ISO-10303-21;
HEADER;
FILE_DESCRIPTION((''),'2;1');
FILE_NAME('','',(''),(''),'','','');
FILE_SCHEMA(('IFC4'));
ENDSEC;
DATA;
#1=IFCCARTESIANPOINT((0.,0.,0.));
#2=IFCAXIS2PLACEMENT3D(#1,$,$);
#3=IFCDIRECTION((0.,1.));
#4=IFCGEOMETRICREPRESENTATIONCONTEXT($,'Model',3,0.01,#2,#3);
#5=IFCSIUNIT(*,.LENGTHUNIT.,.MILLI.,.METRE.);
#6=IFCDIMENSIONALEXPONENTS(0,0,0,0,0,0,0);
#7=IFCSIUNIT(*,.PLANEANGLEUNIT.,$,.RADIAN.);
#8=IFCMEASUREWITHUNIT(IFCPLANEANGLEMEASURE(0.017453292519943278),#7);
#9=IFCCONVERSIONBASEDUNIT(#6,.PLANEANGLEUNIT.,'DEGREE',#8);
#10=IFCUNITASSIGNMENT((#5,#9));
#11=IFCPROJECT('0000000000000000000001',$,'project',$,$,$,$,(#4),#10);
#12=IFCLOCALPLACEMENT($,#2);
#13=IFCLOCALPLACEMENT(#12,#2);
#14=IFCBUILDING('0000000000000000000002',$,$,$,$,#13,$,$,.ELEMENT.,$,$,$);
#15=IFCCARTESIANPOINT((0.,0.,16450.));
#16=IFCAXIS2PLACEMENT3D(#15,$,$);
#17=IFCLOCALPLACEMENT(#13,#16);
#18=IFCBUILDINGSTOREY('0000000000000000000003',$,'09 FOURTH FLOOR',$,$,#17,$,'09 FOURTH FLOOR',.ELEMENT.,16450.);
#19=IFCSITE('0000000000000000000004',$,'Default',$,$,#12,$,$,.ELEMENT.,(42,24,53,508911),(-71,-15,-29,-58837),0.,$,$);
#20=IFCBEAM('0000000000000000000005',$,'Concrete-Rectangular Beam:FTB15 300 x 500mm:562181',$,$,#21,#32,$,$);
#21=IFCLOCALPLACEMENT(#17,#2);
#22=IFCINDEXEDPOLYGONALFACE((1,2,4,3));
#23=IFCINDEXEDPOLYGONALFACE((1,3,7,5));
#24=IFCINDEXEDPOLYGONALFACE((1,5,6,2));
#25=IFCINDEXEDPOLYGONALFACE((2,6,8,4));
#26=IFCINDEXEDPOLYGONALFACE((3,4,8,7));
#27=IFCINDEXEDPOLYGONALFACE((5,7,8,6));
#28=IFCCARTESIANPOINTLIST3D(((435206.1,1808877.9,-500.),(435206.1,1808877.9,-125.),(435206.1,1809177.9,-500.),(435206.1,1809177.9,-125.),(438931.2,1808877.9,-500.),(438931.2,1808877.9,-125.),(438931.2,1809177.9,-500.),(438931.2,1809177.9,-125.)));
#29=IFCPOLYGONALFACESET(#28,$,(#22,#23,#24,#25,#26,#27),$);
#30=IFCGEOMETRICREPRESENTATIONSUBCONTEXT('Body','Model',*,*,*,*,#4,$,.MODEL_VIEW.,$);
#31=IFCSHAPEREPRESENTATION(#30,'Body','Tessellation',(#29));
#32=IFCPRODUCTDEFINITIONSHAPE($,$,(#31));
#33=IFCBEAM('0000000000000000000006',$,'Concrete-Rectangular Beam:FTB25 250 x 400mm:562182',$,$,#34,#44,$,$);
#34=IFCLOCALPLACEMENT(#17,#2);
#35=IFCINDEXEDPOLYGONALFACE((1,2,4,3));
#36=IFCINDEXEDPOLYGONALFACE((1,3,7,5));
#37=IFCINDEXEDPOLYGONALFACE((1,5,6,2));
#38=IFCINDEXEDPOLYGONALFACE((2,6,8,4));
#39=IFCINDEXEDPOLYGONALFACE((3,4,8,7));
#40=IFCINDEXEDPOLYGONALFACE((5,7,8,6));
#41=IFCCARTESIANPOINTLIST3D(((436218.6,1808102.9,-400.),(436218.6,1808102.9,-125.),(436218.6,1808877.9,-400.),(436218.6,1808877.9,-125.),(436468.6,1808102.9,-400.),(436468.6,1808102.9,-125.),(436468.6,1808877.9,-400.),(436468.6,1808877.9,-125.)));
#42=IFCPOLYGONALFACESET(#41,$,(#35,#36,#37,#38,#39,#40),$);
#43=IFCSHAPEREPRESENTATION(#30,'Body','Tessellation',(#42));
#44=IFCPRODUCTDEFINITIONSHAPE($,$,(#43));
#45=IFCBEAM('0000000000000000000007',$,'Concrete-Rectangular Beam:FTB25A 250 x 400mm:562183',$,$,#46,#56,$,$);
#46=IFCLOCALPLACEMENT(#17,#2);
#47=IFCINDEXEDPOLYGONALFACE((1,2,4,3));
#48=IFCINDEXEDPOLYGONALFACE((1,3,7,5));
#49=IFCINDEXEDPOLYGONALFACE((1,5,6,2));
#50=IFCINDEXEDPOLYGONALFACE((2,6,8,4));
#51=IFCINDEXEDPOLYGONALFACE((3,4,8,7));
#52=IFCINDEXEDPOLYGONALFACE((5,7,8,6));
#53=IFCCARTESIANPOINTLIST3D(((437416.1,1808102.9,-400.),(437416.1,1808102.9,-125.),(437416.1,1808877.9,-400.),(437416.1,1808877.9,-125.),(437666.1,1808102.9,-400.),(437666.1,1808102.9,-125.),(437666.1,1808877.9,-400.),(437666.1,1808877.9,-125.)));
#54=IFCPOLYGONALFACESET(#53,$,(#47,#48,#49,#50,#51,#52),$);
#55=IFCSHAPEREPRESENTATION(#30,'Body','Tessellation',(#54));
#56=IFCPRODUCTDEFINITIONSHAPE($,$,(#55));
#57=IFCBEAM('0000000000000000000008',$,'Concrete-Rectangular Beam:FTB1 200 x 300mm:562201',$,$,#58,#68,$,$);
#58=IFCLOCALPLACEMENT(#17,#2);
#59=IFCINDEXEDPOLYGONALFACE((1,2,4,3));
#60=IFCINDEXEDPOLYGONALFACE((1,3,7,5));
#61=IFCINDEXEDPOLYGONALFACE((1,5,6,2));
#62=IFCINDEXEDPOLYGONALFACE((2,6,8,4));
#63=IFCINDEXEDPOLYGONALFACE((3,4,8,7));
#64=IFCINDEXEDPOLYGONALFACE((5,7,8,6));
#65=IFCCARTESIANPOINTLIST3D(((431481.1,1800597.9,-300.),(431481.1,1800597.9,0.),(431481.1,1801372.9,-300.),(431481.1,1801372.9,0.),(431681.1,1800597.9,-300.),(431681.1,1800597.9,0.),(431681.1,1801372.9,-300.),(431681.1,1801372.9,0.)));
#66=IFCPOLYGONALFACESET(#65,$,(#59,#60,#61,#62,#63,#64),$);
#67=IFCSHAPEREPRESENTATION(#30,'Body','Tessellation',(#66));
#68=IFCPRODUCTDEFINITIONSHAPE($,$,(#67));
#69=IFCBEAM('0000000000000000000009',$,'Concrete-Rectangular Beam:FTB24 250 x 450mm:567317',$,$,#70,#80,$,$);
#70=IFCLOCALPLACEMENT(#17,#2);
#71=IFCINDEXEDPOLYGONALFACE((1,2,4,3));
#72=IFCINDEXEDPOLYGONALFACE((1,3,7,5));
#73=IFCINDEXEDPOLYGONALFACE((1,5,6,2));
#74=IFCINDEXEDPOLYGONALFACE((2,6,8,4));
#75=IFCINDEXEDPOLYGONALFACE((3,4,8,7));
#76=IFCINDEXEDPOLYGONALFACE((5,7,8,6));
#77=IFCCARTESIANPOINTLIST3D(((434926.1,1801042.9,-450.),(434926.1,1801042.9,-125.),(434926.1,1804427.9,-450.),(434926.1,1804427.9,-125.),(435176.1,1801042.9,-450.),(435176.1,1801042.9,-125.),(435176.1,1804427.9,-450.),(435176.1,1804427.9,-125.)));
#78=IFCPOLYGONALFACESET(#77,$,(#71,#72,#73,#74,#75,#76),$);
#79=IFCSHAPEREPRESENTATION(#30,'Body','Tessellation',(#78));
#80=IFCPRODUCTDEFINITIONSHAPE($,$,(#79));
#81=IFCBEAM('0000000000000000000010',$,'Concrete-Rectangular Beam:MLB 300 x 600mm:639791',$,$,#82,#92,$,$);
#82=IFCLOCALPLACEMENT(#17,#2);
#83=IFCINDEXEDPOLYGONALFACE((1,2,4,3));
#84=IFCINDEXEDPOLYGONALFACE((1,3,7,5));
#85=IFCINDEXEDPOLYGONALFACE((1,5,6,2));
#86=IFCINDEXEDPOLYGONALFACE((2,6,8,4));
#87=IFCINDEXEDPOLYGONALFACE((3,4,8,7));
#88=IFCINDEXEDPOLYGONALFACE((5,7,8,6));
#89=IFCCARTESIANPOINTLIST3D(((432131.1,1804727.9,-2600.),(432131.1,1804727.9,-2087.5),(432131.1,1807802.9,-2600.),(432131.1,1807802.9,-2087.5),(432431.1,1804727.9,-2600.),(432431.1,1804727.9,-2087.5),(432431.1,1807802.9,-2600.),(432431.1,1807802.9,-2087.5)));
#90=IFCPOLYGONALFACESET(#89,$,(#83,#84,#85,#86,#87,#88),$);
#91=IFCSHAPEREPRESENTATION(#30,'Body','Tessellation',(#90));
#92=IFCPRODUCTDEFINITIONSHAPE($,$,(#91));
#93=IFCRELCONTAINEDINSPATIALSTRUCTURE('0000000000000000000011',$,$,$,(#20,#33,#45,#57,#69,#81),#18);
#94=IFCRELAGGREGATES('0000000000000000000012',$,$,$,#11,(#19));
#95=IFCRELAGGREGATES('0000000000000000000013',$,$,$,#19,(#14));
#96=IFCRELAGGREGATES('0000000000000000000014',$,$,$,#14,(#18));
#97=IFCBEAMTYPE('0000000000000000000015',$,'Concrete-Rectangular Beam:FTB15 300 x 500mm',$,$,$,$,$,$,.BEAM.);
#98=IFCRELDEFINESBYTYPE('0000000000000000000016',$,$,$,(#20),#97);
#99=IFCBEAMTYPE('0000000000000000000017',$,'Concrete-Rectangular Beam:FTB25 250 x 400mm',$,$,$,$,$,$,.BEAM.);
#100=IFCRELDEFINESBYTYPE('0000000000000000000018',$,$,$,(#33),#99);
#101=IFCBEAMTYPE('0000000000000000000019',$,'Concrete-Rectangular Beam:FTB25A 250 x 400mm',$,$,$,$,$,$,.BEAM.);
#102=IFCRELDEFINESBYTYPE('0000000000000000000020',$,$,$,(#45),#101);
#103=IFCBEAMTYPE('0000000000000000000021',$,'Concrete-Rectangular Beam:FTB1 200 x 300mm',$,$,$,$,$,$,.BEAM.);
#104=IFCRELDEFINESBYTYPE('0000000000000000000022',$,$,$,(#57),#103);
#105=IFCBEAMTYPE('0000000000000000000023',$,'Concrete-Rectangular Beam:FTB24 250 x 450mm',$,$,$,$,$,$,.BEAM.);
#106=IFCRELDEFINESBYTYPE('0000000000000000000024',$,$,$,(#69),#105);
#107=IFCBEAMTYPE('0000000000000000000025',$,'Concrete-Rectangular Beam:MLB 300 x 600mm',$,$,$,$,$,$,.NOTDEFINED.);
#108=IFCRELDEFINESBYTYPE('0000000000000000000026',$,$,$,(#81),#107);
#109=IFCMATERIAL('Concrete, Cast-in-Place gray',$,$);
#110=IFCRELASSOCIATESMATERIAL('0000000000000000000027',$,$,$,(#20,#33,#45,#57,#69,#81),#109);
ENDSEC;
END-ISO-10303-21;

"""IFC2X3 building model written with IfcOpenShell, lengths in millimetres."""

from ifc_helpers import new_model, entity, si_unit, converted_unit, direction, frame, frame_2d, origin, origin_2d_with_axis, place, context, subcontext, project, spatial, rectangle, extrude, material, type_object, element, save


model = new_model("IFC2X3")

# Units and contexts
model_context = context("Model", 3, precision=0.01, world=origin(), true_north=direction((0.0, 1.0)))
body_context = subcontext(model_context, "Body", "Model", "MODEL_VIEW")
ifc_project = project(units=[si_unit("LENGTHUNIT", "METRE", prefix="MILLI"), converted_unit("PLANEANGLEUNIT", "DEGREE", entity("IfcPlaneAngleMeasure", 0.017453292519943278), si_unit("PLANEANGLEUNIT", "RADIAN"), dimensions=[0, 0, 0, 0, 0, 0, 0])], contexts=[model_context])

# Site, building, storey
site_placement = place(None, origin())
site = spatial("IfcSite", under=ifc_project, at=site_placement, Name="Default", CompositionType="ELEMENT", RefLatitude=(42, 24, 53, 508911), RefLongitude=(-71, -15, -29, -58837), RefElevation=0.0)
building_placement = place(site_placement, origin())
building = spatial("IfcBuilding", under=site, at=building_placement, CompositionType="ELEMENT")
storey_placement = place(building_placement, frame((0.0, 0.0, 16450.0)))
storey = spatial("IfcBuildingStorey", under=building, at=storey_placement, Name="09 FOURTH FLOOR", LongName="09 FOURTH FLOOR", CompositionType="ELEMENT", Elevation=16450.0)

# Beams
ifc_material = material(Name="Concrete, Cast-in-Place gray")
beam_type_1 = type_object("IfcBeamType", Name="Concrete-Rectangular Beam:FTB15 300 x 500mm", PredefinedType="BEAM")
beam_1_placement = place(storey_placement, frame((435206.1, 1808877.9, 0.0)))
element("IfcBeam", 1, at=beam_1_placement, inside=storey, type_object=beam_type_1, material=ifc_material, Name="Concrete-Rectangular Beam:FTB15 300 x 500mm:562181", context=body_context, shape_type="SweptSolid", body=[
    extrude(rectangle(XDim=375.0, YDim=300.0, at=origin_2d_with_axis()), frame((0.0, 150.0, -312.5), z_axis=(1.0, 0.0, 0.0), x_axis=(0.0, 0.0, -1.0)), (0.0, 0.0, 1.0), 3725.1),
])
beam_type_2 = type_object("IfcBeamType", Name="Concrete-Rectangular Beam:FTB25 250 x 400mm", PredefinedType="BEAM")
beam_2_placement = place(storey_placement, frame((436218.6, 1808877.9, 0.0), z_axis=(0.0, 0.0, 1.0), x_axis=(0.0, -1.0, 0.0)))
element("IfcBeam", 2, at=beam_2_placement, inside=storey, type_object=beam_type_2, material=ifc_material, Name="Concrete-Rectangular Beam:FTB25 250 x 400mm:562182", context=body_context, shape_type="SweptSolid", body=[
    extrude(rectangle(XDim=275.0, YDim=250.0, at=frame_2d((0.0, 0.0), x_axis=(1.0, 0.0))), frame((0.0, 125.0, -262.5), z_axis=(1.0, 0.0, 0.0), x_axis=(0.0, 0.0, -1.0)), (0.0, 0.0, 1.0), 775.0),
])
beam_type_3 = type_object("IfcBeamType", Name="Concrete-Rectangular Beam:FTB25A 250 x 400mm", PredefinedType="BEAM")
beam_3_placement = place(storey_placement, frame((437416.1, 1808877.9, 0.0), z_axis=(0.0, 0.0, 1.0), x_axis=(0.0, -1.0, 0.0)))
element("IfcBeam", 3, at=beam_3_placement, inside=storey, type_object=beam_type_3, material=ifc_material, Name="Concrete-Rectangular Beam:FTB25A 250 x 400mm:562183", context=body_context, shape_type="SweptSolid", body=[
    extrude(rectangle(XDim=275.0, YDim=250.0, at=frame_2d((0.0, 0.0), x_axis=(1.0, 0.0))), frame((0.0, 125.0, -262.5), z_axis=(1.0, 0.0, 0.0), x_axis=(0.0, 0.0, -1.0)), (0.0, 0.0, 1.0), 775.0),
])
beam_type_4 = type_object("IfcBeamType", Name="Concrete-Rectangular Beam:FTB1 200 x 300mm", PredefinedType="BEAM")
beam_4_placement = place(storey_placement, frame((431681.1, 1801372.9, 0.0), z_axis=(0.0, 0.0, 1.0), x_axis=(0.0, -1.0, 0.0)))
element("IfcBeam", 4, at=beam_4_placement, inside=storey, type_object=beam_type_4, material=ifc_material, Name="Concrete-Rectangular Beam:FTB1 200 x 300mm:562201", context=body_context, shape_type="SweptSolid", body=[
    extrude(rectangle(XDim=300.0, YDim=200.0, at=frame_2d((0.0, 0.0), x_axis=(1.0, 0.0))), frame((0.0, -100.0, -150.0), z_axis=(1.0, 0.0, 0.0), x_axis=(0.0, 0.0, -1.0)), (0.0, 0.0, 1.0), 775.0),
])
beam_type_5 = type_object("IfcBeamType", Name="Concrete-Rectangular Beam:FTB24 250 x 450mm", PredefinedType="BEAM")
beam_5_placement = place(storey_placement, frame((435176.1, 1804427.9, 0.0), z_axis=(0.0, 0.0, 1.0), x_axis=(0.0, -1.0, 0.0)))
element("IfcBeam", 5, at=beam_5_placement, inside=storey, type_object=beam_type_5, material=ifc_material, Name="Concrete-Rectangular Beam:FTB24 250 x 450mm:567317", context=body_context, shape_type="SweptSolid", body=[
    extrude(rectangle(XDim=325.0, YDim=250.0, at=frame_2d((0.0, 0.0), x_axis=(1.0, 0.0))), frame((0.0, -125.0, -287.5), z_axis=(1.0, 0.0, 0.0), x_axis=(0.0, 0.0, -1.0)), (0.0, 0.0, 1.0), 3385.0),
])
beam_type_6 = type_object("IfcBeamType", Name="Concrete-Rectangular Beam:MLB 300 x 600mm", PredefinedType="NOTDEFINED")
beam_6_placement = place(storey_placement, frame((432131.1, 1807802.9, -2000.0), z_axis=(0.0, 0.0, 1.0), x_axis=(0.0, -1.0, 0.0)))
element("IfcBeam", 6, at=beam_6_placement, inside=storey, type_object=beam_type_6, material=ifc_material, Name="Concrete-Rectangular Beam:MLB 300 x 600mm:639791", context=body_context, shape_type="SweptSolid", body=[
    extrude(rectangle(XDim=512.5, YDim=300.0, at=frame_2d((0.0, 0.0), x_axis=(1.0, 0.0))), frame((0.0, 150.0, -343.8), z_axis=(1.0, 0.0, 0.0), x_axis=(0.0, 0.0, -1.0)), (0.0, 0.0, 1.0), 3075.0),
])

save(model, "model.ifc")
